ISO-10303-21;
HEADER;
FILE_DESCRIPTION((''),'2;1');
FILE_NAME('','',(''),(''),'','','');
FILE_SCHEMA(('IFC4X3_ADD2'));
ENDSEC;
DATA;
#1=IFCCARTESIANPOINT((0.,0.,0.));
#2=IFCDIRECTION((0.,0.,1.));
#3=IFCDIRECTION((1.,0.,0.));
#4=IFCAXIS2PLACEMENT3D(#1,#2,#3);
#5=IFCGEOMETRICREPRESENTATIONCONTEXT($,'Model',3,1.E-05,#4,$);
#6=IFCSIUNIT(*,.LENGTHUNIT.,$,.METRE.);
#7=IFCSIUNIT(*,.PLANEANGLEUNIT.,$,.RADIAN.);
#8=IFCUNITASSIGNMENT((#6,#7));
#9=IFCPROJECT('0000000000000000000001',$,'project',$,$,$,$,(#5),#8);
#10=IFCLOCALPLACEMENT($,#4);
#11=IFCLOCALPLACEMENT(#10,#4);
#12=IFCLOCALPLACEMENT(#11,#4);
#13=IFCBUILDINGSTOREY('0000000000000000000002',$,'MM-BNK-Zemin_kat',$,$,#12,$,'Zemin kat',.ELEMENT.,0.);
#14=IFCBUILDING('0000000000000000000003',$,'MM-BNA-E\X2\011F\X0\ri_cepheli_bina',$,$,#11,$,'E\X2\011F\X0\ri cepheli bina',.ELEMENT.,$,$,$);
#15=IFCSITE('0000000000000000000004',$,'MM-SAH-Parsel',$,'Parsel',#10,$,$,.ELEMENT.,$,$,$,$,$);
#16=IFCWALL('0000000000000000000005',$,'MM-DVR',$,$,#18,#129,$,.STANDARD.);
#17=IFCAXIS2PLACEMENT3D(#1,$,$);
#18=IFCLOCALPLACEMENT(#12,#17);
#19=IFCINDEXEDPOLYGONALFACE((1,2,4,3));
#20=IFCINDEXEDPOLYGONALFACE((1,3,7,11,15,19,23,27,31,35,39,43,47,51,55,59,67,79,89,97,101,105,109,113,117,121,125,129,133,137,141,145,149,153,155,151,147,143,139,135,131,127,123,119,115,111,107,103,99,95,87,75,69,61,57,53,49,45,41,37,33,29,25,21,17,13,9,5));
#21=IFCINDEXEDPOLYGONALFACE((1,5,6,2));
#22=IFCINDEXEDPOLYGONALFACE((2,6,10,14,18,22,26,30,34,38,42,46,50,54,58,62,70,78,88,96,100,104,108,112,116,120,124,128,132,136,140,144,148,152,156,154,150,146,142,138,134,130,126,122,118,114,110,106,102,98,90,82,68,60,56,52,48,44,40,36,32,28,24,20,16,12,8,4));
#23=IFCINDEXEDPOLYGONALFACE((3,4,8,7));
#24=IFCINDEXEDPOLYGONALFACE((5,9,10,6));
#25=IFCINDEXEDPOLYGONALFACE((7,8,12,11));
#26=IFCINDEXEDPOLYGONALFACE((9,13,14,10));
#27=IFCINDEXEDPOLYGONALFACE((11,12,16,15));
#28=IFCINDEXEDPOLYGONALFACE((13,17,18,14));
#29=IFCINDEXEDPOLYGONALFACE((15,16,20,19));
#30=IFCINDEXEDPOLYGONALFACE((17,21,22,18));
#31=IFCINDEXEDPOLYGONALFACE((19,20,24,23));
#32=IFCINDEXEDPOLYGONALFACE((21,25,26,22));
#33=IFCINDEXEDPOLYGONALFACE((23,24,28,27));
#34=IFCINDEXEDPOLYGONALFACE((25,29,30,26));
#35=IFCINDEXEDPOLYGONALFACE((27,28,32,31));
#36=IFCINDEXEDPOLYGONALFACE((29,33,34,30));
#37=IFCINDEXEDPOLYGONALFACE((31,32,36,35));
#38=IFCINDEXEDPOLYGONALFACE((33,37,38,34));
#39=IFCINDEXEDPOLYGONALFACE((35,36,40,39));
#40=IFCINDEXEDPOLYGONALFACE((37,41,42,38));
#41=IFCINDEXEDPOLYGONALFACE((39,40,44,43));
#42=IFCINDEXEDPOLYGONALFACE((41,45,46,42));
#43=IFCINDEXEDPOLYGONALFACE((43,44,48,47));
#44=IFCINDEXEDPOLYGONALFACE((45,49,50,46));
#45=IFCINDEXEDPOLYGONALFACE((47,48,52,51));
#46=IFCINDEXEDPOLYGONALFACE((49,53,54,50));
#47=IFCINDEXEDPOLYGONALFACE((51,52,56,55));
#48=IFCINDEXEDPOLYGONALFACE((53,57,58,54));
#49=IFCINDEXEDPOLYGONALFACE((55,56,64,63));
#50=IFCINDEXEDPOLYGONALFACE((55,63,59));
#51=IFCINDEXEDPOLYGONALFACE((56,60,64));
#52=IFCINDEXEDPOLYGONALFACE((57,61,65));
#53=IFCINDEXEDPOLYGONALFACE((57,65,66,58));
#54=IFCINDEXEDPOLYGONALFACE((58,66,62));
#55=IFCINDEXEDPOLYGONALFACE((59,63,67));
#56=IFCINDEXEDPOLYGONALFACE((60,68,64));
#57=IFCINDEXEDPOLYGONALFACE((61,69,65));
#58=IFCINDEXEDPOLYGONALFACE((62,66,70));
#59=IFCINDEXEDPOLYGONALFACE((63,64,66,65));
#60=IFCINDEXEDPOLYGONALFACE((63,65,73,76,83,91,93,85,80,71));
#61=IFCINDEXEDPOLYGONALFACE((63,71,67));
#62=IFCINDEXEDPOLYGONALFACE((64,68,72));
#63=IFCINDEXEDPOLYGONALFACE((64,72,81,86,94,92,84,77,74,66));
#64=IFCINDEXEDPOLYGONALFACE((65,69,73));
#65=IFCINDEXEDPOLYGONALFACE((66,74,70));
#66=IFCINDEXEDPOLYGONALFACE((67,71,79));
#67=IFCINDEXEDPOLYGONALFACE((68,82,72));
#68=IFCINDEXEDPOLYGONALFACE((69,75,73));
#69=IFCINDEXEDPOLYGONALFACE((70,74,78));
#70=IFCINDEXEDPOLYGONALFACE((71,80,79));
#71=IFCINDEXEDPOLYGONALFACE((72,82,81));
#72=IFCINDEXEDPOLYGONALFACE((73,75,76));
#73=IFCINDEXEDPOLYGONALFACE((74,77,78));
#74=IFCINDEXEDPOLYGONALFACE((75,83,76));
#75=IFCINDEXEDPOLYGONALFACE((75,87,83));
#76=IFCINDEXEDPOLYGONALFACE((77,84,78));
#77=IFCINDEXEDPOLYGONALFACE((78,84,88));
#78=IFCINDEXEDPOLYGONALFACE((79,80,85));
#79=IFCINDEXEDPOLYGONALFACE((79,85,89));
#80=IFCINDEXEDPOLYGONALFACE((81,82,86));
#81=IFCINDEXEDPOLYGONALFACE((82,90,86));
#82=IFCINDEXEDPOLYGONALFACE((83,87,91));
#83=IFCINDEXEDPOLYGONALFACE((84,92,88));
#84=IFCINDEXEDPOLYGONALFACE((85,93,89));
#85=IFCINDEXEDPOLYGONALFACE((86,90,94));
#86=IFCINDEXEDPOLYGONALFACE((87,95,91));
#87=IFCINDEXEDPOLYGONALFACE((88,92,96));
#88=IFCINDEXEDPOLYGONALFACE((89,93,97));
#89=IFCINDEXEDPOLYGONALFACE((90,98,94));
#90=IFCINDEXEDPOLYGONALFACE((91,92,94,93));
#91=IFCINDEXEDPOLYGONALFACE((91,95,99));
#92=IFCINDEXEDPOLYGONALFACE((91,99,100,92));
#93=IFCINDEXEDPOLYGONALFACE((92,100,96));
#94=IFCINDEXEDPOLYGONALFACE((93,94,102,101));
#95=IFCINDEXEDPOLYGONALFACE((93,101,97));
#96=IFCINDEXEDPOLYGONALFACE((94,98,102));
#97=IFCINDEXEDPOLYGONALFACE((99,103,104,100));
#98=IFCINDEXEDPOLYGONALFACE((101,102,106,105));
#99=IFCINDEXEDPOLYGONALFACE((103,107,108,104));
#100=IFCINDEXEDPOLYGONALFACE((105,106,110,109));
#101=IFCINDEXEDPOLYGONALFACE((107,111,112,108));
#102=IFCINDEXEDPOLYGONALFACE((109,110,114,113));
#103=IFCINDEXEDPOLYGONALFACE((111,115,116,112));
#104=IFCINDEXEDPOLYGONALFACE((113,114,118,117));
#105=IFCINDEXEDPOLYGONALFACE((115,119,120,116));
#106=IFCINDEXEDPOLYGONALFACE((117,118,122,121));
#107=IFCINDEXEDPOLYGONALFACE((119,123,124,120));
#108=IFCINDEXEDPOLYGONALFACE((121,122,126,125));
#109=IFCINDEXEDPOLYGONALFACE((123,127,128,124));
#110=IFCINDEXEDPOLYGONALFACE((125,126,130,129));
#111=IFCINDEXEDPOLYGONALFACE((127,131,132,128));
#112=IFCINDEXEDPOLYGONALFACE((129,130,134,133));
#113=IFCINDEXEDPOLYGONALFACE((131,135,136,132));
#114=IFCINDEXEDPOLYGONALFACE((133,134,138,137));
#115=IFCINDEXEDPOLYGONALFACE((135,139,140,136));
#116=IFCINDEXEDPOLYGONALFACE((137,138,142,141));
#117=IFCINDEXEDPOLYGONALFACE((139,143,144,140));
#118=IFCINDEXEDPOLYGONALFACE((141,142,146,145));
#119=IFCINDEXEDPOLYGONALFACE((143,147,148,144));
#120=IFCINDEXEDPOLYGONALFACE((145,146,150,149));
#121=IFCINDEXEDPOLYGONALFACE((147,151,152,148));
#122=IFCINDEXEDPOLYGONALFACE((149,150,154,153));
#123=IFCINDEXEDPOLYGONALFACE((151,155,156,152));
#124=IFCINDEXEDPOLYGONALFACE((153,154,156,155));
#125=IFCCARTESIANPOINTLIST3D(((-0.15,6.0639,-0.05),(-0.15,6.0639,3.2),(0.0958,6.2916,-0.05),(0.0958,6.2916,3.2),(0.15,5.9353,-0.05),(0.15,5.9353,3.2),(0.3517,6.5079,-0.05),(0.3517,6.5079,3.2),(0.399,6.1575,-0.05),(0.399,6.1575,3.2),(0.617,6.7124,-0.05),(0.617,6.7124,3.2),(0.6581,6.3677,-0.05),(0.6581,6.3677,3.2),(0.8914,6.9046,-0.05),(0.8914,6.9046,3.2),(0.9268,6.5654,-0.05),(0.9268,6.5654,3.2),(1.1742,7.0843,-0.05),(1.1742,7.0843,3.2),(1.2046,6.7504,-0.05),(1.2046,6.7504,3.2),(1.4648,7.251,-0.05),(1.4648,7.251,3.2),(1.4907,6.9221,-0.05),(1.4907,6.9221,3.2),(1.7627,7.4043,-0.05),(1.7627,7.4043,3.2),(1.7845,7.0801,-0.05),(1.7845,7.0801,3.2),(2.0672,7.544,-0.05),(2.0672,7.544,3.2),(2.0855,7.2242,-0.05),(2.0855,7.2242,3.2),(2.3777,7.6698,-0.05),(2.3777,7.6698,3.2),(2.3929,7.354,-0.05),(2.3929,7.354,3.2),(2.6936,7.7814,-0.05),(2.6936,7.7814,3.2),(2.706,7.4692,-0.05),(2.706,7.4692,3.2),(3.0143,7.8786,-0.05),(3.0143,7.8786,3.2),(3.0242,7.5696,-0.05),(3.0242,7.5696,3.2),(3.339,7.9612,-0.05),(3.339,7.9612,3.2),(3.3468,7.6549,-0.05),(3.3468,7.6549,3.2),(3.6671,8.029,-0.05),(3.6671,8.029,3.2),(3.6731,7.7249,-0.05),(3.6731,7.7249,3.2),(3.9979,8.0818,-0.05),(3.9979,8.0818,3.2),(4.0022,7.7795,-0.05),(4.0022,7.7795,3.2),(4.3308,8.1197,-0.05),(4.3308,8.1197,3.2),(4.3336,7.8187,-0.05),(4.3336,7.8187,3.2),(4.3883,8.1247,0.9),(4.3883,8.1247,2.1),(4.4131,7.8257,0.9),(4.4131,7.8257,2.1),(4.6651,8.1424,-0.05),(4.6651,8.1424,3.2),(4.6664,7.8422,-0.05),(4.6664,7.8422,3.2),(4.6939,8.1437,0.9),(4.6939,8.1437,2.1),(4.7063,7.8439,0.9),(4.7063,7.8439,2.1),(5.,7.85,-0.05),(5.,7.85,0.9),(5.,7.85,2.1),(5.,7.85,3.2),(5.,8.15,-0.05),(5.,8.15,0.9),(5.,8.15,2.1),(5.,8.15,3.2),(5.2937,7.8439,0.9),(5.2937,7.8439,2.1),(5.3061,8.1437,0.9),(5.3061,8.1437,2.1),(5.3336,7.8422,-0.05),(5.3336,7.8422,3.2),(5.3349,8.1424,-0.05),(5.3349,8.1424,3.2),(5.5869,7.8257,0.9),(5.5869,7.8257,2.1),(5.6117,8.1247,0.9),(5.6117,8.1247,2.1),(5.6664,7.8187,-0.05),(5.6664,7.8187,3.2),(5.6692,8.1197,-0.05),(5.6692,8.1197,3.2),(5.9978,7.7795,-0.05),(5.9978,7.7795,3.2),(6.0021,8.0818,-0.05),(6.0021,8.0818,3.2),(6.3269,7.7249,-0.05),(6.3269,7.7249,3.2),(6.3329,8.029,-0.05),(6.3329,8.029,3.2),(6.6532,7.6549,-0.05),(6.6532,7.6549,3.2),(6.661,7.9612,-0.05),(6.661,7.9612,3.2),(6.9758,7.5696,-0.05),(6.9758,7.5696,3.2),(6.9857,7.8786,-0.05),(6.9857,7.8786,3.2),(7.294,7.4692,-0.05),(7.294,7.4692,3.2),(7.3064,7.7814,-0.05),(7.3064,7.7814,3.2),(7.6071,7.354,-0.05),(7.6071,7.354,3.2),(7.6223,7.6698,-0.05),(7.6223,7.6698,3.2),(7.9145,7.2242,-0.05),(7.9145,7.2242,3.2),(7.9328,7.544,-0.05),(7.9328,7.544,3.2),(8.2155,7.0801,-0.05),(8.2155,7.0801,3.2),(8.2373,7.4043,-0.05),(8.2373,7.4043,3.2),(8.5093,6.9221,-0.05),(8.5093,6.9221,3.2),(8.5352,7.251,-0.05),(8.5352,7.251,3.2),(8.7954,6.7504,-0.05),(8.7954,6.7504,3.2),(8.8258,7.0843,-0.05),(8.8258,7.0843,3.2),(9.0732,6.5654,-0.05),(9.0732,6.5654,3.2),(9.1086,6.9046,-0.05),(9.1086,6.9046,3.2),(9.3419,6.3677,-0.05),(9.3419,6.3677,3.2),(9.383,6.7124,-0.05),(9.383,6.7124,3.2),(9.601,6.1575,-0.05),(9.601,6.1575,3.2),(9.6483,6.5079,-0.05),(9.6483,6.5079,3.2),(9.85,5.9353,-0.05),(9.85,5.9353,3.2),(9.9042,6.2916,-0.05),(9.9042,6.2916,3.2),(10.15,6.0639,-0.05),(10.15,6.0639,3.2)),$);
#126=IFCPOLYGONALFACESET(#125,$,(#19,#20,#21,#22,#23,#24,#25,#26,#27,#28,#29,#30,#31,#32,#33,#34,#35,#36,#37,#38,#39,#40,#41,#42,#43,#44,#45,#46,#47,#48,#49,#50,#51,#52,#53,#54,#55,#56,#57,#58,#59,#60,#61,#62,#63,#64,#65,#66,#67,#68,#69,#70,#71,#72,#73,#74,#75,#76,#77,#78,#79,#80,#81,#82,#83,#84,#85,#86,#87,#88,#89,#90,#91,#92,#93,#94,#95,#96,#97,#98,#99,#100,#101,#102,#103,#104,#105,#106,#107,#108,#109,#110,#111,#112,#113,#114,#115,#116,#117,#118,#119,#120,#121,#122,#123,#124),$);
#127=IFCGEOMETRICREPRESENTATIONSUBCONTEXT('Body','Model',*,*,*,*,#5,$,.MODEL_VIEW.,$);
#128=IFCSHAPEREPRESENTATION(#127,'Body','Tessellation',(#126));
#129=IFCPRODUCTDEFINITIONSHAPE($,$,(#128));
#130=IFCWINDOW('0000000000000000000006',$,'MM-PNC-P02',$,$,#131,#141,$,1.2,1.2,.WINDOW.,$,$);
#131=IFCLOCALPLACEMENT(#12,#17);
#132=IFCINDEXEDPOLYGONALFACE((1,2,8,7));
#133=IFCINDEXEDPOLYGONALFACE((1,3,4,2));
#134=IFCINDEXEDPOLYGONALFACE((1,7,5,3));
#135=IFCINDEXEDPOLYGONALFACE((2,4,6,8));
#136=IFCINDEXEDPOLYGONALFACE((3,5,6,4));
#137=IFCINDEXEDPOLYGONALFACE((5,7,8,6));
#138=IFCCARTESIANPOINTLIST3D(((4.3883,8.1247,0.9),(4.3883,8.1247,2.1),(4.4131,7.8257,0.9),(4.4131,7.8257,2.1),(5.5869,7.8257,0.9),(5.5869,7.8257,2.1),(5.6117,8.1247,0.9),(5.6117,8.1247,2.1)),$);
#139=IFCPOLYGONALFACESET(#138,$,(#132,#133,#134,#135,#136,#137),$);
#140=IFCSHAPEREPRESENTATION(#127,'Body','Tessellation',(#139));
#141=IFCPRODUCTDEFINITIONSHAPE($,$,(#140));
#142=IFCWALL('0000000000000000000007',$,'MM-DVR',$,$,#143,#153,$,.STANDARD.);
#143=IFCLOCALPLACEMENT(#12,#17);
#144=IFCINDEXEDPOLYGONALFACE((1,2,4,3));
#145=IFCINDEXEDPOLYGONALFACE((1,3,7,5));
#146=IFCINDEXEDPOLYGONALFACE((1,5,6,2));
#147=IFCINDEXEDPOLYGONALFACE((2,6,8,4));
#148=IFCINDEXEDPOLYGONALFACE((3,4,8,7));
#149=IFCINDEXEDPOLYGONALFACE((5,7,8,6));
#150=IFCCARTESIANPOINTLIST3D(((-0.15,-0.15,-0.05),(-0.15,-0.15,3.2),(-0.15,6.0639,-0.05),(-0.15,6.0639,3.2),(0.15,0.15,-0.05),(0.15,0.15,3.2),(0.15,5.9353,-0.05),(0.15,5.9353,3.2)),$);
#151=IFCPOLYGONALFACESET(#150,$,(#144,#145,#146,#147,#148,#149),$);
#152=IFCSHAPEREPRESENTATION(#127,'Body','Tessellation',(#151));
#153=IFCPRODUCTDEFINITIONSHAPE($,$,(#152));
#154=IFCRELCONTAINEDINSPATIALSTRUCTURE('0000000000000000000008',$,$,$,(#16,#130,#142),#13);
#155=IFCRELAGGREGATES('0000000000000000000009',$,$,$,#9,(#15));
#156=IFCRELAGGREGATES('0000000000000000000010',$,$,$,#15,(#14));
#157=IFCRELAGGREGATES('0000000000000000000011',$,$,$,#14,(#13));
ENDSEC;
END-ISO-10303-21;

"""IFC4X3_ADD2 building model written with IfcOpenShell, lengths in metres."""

from ifc_helpers import new_model, si_unit, frame, origin_with_axes, place, context, subcontext, project, spatial, polyline, line, arc, indexed_curve, outline, extrude, element, fill, save


model = new_model("IFC4X3_ADD2")

# Units and contexts
model_context = context("Model", 3, precision=1e-05, world=origin_with_axes())
body_context = subcontext(model_context, "Body", "Model", "MODEL_VIEW")
ifc_project = project(units=[si_unit("LENGTHUNIT", "METRE"), si_unit("PLANEANGLEUNIT", "RADIAN")], contexts=[model_context])

# Site, building, storey
site_placement = place(None, origin_with_axes())
site = spatial("IfcSite", under=ifc_project, at=site_placement, Name="MM-SAH-Parsel", ObjectType="Parsel", CompositionType="ELEMENT")
building_placement = place(site_placement, origin_with_axes())
building = spatial("IfcBuilding", under=site, at=building_placement, Name="MM-BNA-Eğri_cepheli_bina", LongName="Eğri cepheli bina", CompositionType="ELEMENT")
storey_placement = place(building_placement, origin_with_axes())
storey = spatial("IfcBuildingStorey", under=building, at=storey_placement, Name="MM-BNK-Zemin_kat", LongName="Zemin kat", CompositionType="ELEMENT", Elevation=0.0)

# Wall, opening, window
wall_1_placement = place(storey_placement, origin_with_axes())
wall_1 = element("IfcWall", 1, at=wall_1_placement, inside=storey, Name="MM-DVR", PredefinedType="STANDARD", context=body_context, shape_type="SweptSolid", body=[
    extrude(outline(indexed_curve([(9.85, 5.9353), (5.0, 7.85), (0.15, 5.9353), (-0.15, 6.0639), (5.0, 8.15), (10.15, 6.0639)], segments=[arc(1, 2, 3), line(3, 4), arc(4, 5, 6), line(6, 1)], self_intersect=False)), frame((0.0, 0.0, -0.05)), (0.0, 0.0, 1.0), 3.25),
])
opening_1_placement = place(storey_placement, origin_with_axes())
opening_1 = element("IfcOpeningElement", 2, at=opening_1_placement, cuts=wall_1, PredefinedType="OPENING", context=body_context, shape_type="SweptSolid", body=[
    extrude(outline(indexed_curve([(5.5869, 7.8257), (5.0, 7.85), (4.4131, 7.8257), (4.3883, 8.1247), (5.0, 8.15), (5.6117, 8.1247)], segments=[arc(1, 2, 3), line(3, 4), arc(4, 5, 6), line(6, 1)], self_intersect=False)), frame((0.0, 0.0, 0.9)), (0.0, 0.0, 1.0), 1.2),
])
window_1_placement = place(storey_placement, origin_with_axes())
window_1 = element("IfcWindow", 3, at=window_1_placement, inside=storey, Name="MM-PNC-P02", OverallHeight=1.2, OverallWidth=1.2, PredefinedType="WINDOW", context=body_context, shape_type="SweptSolid", body=[
    extrude(outline(polyline([(5.5869, 7.8257), (4.4131, 7.8257), (4.3883, 8.1247), (5.6117, 8.1247), (5.5869, 7.8257)])), frame((0.0, 0.0, 0.9)), (0.0, 0.0, 1.0), 1.2),
])
fill(opening_1, window_1)

# Wall
wall_2_placement = place(storey_placement, origin_with_axes())
element("IfcWall", 4, at=wall_2_placement, inside=storey, Name="MM-DVR", PredefinedType="STANDARD", context=body_context, shape_type="SweptSolid", body=[
    extrude(outline(polyline([(0.15, 5.9353), (0.15, 0.15), (-0.15, -0.15), (-0.15, 6.0639), (0.15, 5.9353)])), frame((0.0, 0.0, -0.05)), (0.0, 0.0, 1.0), 3.25),
])

save(model, "model.ifc")
